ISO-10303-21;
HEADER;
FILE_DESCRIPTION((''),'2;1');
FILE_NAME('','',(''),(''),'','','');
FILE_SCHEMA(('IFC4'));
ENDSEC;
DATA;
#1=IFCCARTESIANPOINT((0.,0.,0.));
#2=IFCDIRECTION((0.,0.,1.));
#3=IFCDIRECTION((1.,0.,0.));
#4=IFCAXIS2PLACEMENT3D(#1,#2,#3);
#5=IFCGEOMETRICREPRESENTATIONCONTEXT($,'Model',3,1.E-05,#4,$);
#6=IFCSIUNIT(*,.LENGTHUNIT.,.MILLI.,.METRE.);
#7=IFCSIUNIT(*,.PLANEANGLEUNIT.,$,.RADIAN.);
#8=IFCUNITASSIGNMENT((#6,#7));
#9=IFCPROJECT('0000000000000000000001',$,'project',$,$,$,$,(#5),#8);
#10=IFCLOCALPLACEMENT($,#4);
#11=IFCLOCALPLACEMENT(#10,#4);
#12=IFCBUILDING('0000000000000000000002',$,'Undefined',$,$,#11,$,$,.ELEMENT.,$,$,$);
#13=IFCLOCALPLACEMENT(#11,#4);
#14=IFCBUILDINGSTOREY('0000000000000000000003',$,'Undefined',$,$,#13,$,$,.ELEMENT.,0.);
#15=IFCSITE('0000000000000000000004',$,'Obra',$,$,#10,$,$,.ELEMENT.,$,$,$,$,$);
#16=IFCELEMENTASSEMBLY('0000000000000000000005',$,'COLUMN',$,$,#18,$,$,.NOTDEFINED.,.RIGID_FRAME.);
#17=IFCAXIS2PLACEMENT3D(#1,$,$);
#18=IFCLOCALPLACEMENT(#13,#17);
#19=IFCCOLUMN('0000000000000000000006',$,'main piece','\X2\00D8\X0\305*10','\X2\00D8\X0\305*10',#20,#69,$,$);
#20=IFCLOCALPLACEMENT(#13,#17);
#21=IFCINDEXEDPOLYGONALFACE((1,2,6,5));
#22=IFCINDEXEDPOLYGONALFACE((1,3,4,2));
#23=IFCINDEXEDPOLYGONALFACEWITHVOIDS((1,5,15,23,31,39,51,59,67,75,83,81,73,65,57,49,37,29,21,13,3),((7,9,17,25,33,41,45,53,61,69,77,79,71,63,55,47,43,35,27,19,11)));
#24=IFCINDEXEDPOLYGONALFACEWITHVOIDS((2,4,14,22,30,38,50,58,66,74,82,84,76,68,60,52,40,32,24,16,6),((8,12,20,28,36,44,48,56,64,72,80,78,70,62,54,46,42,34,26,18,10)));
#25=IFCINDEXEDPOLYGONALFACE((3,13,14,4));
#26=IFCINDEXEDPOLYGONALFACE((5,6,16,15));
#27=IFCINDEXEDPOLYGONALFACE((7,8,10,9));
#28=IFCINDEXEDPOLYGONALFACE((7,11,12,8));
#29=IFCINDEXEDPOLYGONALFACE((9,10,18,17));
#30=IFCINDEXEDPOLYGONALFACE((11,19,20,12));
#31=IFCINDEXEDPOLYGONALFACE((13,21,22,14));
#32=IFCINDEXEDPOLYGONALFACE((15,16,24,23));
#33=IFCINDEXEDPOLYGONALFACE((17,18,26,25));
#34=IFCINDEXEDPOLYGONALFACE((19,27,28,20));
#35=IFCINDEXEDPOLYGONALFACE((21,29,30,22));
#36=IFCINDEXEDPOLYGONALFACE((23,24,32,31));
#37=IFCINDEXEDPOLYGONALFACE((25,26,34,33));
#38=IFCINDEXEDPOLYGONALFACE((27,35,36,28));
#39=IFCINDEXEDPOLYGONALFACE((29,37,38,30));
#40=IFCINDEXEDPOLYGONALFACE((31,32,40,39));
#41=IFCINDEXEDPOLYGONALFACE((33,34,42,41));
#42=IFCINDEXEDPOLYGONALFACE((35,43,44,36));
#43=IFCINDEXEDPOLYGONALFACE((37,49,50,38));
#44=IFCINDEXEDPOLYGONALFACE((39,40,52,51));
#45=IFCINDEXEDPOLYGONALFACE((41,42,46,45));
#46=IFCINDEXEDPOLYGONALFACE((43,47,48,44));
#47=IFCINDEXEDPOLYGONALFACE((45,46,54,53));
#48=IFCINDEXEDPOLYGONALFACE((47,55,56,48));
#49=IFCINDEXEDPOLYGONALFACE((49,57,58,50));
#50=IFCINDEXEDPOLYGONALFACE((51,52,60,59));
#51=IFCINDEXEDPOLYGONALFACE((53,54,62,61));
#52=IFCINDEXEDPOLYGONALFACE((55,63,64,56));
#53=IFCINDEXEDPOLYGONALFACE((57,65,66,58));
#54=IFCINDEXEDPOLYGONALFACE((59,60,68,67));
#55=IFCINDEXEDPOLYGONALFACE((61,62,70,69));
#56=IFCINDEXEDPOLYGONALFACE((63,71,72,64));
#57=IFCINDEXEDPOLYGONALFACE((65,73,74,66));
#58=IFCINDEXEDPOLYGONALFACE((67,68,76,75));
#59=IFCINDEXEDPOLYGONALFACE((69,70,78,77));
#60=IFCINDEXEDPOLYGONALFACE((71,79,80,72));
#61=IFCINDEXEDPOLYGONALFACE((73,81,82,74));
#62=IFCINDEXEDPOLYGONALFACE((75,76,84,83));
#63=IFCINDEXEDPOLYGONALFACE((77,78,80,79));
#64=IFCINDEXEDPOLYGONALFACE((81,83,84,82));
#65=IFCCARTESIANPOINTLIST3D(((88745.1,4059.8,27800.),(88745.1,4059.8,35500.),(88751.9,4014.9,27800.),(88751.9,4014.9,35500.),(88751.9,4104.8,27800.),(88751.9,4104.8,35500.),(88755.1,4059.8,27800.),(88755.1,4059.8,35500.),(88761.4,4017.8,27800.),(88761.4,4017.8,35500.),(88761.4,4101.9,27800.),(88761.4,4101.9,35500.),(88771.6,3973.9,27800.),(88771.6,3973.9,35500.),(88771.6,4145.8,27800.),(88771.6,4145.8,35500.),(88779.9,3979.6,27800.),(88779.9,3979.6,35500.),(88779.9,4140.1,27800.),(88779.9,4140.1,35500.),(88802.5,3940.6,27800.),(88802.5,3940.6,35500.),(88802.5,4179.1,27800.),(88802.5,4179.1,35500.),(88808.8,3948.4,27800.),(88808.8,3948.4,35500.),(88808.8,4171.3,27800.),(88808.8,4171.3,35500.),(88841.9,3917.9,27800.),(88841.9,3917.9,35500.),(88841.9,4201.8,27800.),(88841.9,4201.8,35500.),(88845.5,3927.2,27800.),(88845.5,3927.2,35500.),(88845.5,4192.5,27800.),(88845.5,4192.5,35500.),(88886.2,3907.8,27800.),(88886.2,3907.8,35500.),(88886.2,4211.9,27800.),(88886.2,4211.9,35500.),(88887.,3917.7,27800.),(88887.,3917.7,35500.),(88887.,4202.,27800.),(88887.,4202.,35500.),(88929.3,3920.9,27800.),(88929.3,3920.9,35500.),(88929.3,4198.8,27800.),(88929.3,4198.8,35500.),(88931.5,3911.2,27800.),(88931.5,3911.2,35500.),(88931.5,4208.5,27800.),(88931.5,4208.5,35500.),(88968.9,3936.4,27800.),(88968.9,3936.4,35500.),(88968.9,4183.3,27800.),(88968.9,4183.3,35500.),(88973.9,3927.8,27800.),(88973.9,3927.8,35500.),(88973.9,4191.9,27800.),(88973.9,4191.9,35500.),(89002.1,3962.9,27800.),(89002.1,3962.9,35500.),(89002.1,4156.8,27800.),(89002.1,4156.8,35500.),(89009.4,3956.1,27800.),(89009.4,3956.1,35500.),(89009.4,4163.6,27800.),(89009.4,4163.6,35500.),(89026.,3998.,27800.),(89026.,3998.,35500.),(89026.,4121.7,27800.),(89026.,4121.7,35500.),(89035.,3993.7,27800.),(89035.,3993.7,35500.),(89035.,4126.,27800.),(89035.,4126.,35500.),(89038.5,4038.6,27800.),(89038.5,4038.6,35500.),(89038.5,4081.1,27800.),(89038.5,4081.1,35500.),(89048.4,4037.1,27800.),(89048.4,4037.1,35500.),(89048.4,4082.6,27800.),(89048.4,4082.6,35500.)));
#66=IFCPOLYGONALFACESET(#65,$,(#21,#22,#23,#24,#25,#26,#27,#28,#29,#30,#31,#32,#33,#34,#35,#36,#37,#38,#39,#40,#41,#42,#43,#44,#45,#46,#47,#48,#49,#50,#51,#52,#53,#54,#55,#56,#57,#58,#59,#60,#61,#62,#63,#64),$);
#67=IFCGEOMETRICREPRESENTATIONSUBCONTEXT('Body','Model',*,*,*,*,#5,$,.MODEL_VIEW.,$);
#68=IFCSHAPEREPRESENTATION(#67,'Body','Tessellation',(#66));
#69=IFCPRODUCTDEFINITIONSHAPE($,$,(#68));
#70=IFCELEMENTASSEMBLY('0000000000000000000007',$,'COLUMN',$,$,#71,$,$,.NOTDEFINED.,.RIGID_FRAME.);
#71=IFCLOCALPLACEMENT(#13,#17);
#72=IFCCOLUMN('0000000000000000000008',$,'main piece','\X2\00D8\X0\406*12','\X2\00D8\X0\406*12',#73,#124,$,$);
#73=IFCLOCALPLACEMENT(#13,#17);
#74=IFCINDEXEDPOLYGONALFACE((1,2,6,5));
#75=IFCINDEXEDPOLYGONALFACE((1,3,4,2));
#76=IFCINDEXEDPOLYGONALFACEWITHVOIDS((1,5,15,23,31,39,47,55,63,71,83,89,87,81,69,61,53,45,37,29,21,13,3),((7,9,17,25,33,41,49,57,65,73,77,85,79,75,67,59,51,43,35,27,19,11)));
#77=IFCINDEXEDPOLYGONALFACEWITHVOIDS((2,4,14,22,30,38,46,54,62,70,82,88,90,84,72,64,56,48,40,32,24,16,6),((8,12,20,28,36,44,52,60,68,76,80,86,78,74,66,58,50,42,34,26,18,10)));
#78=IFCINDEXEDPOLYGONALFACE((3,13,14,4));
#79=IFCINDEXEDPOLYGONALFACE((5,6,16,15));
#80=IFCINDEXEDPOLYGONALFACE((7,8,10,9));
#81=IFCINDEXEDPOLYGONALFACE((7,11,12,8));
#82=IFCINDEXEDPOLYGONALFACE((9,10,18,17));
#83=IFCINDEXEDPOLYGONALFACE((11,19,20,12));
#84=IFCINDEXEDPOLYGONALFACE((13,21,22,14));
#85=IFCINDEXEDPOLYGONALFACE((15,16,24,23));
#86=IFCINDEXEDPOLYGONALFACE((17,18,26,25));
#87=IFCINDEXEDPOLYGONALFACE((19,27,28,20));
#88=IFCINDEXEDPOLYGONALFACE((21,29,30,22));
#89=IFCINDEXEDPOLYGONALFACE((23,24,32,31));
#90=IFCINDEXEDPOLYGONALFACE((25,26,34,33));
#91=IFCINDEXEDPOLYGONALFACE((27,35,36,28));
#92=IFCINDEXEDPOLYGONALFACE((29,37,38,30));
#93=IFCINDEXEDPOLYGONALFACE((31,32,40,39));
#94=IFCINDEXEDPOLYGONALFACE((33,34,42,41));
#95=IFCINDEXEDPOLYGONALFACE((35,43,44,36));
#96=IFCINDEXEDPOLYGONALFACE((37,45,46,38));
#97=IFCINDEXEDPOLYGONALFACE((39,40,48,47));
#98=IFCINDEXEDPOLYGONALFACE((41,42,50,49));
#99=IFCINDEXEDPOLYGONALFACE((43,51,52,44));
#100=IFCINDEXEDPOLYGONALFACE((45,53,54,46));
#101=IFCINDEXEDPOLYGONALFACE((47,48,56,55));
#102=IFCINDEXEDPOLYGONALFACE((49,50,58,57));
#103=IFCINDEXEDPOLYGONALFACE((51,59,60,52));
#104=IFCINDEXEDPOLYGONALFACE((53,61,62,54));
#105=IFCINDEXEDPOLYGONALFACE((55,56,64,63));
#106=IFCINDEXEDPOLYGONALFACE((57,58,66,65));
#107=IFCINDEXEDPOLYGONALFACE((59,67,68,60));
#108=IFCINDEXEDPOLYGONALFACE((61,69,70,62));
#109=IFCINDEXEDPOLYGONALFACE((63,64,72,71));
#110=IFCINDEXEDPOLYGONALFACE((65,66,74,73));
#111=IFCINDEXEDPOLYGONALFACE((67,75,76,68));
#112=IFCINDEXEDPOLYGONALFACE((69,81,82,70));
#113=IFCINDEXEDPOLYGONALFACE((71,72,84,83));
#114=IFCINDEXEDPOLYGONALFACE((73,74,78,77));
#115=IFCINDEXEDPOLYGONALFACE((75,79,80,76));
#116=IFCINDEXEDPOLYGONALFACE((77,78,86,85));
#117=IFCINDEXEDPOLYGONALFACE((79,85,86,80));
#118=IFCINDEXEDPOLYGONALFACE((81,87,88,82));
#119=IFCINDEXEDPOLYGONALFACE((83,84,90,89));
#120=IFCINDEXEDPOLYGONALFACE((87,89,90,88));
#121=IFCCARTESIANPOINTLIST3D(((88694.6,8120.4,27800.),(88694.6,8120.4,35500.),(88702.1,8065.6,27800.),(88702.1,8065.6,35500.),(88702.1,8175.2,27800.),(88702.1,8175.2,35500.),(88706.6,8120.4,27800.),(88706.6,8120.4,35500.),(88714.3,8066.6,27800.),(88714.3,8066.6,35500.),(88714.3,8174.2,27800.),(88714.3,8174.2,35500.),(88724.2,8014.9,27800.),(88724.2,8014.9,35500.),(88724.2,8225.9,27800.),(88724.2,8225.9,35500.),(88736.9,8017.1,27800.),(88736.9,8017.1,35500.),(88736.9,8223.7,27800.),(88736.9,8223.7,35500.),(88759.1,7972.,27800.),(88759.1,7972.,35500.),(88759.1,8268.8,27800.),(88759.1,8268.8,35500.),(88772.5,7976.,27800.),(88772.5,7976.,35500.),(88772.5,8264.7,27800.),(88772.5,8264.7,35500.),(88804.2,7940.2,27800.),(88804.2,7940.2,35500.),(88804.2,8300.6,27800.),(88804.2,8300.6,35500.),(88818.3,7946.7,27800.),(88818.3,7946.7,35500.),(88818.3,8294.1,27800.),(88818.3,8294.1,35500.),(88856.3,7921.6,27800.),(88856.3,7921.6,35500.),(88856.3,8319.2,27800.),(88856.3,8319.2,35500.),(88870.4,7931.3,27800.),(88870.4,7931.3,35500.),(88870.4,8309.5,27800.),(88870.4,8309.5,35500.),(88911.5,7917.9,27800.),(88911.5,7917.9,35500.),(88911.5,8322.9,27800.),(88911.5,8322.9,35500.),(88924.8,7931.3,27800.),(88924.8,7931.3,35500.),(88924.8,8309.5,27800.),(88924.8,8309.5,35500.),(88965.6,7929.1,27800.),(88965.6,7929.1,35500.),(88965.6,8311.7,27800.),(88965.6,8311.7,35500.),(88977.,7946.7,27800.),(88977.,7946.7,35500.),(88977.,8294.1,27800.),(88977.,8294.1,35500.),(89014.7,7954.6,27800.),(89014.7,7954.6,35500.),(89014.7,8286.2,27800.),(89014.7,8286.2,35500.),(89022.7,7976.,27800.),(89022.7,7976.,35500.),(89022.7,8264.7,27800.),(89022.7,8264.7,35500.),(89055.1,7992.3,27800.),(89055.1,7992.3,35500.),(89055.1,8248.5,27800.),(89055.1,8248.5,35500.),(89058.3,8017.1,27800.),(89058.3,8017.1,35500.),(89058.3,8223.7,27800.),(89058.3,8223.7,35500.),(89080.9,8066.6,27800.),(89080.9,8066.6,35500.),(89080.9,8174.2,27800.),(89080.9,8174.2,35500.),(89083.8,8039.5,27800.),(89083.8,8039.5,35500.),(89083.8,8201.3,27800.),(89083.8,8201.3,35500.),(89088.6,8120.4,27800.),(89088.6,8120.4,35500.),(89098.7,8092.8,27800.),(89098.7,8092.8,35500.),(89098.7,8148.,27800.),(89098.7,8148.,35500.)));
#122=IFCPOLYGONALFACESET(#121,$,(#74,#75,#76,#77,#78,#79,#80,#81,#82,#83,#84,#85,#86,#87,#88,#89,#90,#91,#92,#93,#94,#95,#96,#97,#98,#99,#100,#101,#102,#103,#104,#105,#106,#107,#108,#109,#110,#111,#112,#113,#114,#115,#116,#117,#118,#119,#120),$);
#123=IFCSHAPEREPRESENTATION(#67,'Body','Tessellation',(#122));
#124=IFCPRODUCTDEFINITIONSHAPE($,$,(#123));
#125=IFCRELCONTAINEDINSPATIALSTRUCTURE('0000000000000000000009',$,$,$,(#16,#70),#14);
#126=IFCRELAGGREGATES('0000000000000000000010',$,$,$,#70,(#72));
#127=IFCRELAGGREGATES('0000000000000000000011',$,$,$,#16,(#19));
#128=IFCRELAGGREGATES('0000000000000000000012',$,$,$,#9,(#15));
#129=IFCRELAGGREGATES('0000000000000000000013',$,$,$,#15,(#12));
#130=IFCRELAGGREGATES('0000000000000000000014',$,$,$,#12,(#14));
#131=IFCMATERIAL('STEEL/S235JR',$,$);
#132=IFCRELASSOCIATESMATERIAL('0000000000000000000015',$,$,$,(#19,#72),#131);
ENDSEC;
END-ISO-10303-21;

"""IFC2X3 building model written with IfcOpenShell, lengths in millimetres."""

from ifc_helpers import new_model, si_unit, frame, origin_with_axes, origin_2d_with_axis, place, context, subcontext, project, spatial, hollow_circle, extrude, material, element, aggregate, save


model = new_model("IFC2X3")

# Units and contexts
model_context = context("Model", 3, precision=1e-05, world=origin_with_axes())
body_context = subcontext(model_context, "Body", "Model", "MODEL_VIEW")
ifc_project = project(units=[si_unit("LENGTHUNIT", "METRE", prefix="MILLI"), si_unit("PLANEANGLEUNIT", "RADIAN")], contexts=[model_context])

# Site, building, storey
site_placement = place(None, origin_with_axes())
site = spatial("IfcSite", under=ifc_project, at=site_placement, Name="Obra", CompositionType="ELEMENT")
building_placement = place(site_placement, origin_with_axes())
building = spatial("IfcBuilding", under=site, at=building_placement, Name="Undefined", CompositionType="ELEMENT")
storey_placement = place(building_placement, origin_with_axes())
storey = spatial("IfcBuildingStorey", under=building, at=storey_placement, Name="Undefined", CompositionType="ELEMENT", Elevation=0.0)

# Element assemblies, columns
assembly_1_placement = place(storey_placement, origin_with_axes())
assembly_1 = element("IfcElementAssembly", 1, at=assembly_1_placement, inside=storey, Name="COLUMN", AssemblyPlace="NOTDEFINED", PredefinedType="RIGID_FRAME")
ifc_material = material(Name="STEEL/S235JR")
column_1_placement = place(assembly_1_placement, frame((88897.6, 4059.8, 27800.0), z_axis=(0.0, 0.0, 1.0), x_axis=(0.0, 1.0, 0.0)))
column_1 = element("IfcColumn", 2, at=column_1_placement, material=ifc_material, Name="main piece", Description="Ø305*10", ObjectType="Ø305*10", context=body_context, shape_type="SweptSolid", body=[
    extrude(hollow_circle(Radius=152.5, WallThickness=10.0, at=origin_2d_with_axis()), frame((0.0, 0.0, 7700.0), z_axis=(0.0, 0.0, -1.0), x_axis=(0.0, 1.0, 0.0)), (0.0, 0.0, 1.0), 7700.0),
])
assembly_2_placement = place(storey_placement, origin_with_axes())
assembly_2 = element("IfcElementAssembly", 3, at=assembly_2_placement, inside=storey, Name="COLUMN", AssemblyPlace="NOTDEFINED", PredefinedType="RIGID_FRAME")
column_2_placement = place(assembly_2_placement, frame((88897.6, 8120.4, 27800.0), z_axis=(0.0, 0.0, 1.0), x_axis=(0.0, 1.0, 0.0)))
column_2 = element("IfcColumn", 4, at=column_2_placement, material=ifc_material, Name="main piece", Description="Ø406*12", ObjectType="Ø406*12", context=body_context, shape_type="SweptSolid", body=[
    extrude(hollow_circle(Radius=203.0, WallThickness=12.0, at=origin_2d_with_axis()), frame((0.0, 0.0, 7700.0), z_axis=(0.0, 0.0, -1.0), x_axis=(0.0, 1.0, 0.0)), (0.0, 0.0, 1.0), 7700.0),
])

aggregate(assembly_2, [column_2])
aggregate(assembly_1, [column_1])

save(model, "model.ifc")
